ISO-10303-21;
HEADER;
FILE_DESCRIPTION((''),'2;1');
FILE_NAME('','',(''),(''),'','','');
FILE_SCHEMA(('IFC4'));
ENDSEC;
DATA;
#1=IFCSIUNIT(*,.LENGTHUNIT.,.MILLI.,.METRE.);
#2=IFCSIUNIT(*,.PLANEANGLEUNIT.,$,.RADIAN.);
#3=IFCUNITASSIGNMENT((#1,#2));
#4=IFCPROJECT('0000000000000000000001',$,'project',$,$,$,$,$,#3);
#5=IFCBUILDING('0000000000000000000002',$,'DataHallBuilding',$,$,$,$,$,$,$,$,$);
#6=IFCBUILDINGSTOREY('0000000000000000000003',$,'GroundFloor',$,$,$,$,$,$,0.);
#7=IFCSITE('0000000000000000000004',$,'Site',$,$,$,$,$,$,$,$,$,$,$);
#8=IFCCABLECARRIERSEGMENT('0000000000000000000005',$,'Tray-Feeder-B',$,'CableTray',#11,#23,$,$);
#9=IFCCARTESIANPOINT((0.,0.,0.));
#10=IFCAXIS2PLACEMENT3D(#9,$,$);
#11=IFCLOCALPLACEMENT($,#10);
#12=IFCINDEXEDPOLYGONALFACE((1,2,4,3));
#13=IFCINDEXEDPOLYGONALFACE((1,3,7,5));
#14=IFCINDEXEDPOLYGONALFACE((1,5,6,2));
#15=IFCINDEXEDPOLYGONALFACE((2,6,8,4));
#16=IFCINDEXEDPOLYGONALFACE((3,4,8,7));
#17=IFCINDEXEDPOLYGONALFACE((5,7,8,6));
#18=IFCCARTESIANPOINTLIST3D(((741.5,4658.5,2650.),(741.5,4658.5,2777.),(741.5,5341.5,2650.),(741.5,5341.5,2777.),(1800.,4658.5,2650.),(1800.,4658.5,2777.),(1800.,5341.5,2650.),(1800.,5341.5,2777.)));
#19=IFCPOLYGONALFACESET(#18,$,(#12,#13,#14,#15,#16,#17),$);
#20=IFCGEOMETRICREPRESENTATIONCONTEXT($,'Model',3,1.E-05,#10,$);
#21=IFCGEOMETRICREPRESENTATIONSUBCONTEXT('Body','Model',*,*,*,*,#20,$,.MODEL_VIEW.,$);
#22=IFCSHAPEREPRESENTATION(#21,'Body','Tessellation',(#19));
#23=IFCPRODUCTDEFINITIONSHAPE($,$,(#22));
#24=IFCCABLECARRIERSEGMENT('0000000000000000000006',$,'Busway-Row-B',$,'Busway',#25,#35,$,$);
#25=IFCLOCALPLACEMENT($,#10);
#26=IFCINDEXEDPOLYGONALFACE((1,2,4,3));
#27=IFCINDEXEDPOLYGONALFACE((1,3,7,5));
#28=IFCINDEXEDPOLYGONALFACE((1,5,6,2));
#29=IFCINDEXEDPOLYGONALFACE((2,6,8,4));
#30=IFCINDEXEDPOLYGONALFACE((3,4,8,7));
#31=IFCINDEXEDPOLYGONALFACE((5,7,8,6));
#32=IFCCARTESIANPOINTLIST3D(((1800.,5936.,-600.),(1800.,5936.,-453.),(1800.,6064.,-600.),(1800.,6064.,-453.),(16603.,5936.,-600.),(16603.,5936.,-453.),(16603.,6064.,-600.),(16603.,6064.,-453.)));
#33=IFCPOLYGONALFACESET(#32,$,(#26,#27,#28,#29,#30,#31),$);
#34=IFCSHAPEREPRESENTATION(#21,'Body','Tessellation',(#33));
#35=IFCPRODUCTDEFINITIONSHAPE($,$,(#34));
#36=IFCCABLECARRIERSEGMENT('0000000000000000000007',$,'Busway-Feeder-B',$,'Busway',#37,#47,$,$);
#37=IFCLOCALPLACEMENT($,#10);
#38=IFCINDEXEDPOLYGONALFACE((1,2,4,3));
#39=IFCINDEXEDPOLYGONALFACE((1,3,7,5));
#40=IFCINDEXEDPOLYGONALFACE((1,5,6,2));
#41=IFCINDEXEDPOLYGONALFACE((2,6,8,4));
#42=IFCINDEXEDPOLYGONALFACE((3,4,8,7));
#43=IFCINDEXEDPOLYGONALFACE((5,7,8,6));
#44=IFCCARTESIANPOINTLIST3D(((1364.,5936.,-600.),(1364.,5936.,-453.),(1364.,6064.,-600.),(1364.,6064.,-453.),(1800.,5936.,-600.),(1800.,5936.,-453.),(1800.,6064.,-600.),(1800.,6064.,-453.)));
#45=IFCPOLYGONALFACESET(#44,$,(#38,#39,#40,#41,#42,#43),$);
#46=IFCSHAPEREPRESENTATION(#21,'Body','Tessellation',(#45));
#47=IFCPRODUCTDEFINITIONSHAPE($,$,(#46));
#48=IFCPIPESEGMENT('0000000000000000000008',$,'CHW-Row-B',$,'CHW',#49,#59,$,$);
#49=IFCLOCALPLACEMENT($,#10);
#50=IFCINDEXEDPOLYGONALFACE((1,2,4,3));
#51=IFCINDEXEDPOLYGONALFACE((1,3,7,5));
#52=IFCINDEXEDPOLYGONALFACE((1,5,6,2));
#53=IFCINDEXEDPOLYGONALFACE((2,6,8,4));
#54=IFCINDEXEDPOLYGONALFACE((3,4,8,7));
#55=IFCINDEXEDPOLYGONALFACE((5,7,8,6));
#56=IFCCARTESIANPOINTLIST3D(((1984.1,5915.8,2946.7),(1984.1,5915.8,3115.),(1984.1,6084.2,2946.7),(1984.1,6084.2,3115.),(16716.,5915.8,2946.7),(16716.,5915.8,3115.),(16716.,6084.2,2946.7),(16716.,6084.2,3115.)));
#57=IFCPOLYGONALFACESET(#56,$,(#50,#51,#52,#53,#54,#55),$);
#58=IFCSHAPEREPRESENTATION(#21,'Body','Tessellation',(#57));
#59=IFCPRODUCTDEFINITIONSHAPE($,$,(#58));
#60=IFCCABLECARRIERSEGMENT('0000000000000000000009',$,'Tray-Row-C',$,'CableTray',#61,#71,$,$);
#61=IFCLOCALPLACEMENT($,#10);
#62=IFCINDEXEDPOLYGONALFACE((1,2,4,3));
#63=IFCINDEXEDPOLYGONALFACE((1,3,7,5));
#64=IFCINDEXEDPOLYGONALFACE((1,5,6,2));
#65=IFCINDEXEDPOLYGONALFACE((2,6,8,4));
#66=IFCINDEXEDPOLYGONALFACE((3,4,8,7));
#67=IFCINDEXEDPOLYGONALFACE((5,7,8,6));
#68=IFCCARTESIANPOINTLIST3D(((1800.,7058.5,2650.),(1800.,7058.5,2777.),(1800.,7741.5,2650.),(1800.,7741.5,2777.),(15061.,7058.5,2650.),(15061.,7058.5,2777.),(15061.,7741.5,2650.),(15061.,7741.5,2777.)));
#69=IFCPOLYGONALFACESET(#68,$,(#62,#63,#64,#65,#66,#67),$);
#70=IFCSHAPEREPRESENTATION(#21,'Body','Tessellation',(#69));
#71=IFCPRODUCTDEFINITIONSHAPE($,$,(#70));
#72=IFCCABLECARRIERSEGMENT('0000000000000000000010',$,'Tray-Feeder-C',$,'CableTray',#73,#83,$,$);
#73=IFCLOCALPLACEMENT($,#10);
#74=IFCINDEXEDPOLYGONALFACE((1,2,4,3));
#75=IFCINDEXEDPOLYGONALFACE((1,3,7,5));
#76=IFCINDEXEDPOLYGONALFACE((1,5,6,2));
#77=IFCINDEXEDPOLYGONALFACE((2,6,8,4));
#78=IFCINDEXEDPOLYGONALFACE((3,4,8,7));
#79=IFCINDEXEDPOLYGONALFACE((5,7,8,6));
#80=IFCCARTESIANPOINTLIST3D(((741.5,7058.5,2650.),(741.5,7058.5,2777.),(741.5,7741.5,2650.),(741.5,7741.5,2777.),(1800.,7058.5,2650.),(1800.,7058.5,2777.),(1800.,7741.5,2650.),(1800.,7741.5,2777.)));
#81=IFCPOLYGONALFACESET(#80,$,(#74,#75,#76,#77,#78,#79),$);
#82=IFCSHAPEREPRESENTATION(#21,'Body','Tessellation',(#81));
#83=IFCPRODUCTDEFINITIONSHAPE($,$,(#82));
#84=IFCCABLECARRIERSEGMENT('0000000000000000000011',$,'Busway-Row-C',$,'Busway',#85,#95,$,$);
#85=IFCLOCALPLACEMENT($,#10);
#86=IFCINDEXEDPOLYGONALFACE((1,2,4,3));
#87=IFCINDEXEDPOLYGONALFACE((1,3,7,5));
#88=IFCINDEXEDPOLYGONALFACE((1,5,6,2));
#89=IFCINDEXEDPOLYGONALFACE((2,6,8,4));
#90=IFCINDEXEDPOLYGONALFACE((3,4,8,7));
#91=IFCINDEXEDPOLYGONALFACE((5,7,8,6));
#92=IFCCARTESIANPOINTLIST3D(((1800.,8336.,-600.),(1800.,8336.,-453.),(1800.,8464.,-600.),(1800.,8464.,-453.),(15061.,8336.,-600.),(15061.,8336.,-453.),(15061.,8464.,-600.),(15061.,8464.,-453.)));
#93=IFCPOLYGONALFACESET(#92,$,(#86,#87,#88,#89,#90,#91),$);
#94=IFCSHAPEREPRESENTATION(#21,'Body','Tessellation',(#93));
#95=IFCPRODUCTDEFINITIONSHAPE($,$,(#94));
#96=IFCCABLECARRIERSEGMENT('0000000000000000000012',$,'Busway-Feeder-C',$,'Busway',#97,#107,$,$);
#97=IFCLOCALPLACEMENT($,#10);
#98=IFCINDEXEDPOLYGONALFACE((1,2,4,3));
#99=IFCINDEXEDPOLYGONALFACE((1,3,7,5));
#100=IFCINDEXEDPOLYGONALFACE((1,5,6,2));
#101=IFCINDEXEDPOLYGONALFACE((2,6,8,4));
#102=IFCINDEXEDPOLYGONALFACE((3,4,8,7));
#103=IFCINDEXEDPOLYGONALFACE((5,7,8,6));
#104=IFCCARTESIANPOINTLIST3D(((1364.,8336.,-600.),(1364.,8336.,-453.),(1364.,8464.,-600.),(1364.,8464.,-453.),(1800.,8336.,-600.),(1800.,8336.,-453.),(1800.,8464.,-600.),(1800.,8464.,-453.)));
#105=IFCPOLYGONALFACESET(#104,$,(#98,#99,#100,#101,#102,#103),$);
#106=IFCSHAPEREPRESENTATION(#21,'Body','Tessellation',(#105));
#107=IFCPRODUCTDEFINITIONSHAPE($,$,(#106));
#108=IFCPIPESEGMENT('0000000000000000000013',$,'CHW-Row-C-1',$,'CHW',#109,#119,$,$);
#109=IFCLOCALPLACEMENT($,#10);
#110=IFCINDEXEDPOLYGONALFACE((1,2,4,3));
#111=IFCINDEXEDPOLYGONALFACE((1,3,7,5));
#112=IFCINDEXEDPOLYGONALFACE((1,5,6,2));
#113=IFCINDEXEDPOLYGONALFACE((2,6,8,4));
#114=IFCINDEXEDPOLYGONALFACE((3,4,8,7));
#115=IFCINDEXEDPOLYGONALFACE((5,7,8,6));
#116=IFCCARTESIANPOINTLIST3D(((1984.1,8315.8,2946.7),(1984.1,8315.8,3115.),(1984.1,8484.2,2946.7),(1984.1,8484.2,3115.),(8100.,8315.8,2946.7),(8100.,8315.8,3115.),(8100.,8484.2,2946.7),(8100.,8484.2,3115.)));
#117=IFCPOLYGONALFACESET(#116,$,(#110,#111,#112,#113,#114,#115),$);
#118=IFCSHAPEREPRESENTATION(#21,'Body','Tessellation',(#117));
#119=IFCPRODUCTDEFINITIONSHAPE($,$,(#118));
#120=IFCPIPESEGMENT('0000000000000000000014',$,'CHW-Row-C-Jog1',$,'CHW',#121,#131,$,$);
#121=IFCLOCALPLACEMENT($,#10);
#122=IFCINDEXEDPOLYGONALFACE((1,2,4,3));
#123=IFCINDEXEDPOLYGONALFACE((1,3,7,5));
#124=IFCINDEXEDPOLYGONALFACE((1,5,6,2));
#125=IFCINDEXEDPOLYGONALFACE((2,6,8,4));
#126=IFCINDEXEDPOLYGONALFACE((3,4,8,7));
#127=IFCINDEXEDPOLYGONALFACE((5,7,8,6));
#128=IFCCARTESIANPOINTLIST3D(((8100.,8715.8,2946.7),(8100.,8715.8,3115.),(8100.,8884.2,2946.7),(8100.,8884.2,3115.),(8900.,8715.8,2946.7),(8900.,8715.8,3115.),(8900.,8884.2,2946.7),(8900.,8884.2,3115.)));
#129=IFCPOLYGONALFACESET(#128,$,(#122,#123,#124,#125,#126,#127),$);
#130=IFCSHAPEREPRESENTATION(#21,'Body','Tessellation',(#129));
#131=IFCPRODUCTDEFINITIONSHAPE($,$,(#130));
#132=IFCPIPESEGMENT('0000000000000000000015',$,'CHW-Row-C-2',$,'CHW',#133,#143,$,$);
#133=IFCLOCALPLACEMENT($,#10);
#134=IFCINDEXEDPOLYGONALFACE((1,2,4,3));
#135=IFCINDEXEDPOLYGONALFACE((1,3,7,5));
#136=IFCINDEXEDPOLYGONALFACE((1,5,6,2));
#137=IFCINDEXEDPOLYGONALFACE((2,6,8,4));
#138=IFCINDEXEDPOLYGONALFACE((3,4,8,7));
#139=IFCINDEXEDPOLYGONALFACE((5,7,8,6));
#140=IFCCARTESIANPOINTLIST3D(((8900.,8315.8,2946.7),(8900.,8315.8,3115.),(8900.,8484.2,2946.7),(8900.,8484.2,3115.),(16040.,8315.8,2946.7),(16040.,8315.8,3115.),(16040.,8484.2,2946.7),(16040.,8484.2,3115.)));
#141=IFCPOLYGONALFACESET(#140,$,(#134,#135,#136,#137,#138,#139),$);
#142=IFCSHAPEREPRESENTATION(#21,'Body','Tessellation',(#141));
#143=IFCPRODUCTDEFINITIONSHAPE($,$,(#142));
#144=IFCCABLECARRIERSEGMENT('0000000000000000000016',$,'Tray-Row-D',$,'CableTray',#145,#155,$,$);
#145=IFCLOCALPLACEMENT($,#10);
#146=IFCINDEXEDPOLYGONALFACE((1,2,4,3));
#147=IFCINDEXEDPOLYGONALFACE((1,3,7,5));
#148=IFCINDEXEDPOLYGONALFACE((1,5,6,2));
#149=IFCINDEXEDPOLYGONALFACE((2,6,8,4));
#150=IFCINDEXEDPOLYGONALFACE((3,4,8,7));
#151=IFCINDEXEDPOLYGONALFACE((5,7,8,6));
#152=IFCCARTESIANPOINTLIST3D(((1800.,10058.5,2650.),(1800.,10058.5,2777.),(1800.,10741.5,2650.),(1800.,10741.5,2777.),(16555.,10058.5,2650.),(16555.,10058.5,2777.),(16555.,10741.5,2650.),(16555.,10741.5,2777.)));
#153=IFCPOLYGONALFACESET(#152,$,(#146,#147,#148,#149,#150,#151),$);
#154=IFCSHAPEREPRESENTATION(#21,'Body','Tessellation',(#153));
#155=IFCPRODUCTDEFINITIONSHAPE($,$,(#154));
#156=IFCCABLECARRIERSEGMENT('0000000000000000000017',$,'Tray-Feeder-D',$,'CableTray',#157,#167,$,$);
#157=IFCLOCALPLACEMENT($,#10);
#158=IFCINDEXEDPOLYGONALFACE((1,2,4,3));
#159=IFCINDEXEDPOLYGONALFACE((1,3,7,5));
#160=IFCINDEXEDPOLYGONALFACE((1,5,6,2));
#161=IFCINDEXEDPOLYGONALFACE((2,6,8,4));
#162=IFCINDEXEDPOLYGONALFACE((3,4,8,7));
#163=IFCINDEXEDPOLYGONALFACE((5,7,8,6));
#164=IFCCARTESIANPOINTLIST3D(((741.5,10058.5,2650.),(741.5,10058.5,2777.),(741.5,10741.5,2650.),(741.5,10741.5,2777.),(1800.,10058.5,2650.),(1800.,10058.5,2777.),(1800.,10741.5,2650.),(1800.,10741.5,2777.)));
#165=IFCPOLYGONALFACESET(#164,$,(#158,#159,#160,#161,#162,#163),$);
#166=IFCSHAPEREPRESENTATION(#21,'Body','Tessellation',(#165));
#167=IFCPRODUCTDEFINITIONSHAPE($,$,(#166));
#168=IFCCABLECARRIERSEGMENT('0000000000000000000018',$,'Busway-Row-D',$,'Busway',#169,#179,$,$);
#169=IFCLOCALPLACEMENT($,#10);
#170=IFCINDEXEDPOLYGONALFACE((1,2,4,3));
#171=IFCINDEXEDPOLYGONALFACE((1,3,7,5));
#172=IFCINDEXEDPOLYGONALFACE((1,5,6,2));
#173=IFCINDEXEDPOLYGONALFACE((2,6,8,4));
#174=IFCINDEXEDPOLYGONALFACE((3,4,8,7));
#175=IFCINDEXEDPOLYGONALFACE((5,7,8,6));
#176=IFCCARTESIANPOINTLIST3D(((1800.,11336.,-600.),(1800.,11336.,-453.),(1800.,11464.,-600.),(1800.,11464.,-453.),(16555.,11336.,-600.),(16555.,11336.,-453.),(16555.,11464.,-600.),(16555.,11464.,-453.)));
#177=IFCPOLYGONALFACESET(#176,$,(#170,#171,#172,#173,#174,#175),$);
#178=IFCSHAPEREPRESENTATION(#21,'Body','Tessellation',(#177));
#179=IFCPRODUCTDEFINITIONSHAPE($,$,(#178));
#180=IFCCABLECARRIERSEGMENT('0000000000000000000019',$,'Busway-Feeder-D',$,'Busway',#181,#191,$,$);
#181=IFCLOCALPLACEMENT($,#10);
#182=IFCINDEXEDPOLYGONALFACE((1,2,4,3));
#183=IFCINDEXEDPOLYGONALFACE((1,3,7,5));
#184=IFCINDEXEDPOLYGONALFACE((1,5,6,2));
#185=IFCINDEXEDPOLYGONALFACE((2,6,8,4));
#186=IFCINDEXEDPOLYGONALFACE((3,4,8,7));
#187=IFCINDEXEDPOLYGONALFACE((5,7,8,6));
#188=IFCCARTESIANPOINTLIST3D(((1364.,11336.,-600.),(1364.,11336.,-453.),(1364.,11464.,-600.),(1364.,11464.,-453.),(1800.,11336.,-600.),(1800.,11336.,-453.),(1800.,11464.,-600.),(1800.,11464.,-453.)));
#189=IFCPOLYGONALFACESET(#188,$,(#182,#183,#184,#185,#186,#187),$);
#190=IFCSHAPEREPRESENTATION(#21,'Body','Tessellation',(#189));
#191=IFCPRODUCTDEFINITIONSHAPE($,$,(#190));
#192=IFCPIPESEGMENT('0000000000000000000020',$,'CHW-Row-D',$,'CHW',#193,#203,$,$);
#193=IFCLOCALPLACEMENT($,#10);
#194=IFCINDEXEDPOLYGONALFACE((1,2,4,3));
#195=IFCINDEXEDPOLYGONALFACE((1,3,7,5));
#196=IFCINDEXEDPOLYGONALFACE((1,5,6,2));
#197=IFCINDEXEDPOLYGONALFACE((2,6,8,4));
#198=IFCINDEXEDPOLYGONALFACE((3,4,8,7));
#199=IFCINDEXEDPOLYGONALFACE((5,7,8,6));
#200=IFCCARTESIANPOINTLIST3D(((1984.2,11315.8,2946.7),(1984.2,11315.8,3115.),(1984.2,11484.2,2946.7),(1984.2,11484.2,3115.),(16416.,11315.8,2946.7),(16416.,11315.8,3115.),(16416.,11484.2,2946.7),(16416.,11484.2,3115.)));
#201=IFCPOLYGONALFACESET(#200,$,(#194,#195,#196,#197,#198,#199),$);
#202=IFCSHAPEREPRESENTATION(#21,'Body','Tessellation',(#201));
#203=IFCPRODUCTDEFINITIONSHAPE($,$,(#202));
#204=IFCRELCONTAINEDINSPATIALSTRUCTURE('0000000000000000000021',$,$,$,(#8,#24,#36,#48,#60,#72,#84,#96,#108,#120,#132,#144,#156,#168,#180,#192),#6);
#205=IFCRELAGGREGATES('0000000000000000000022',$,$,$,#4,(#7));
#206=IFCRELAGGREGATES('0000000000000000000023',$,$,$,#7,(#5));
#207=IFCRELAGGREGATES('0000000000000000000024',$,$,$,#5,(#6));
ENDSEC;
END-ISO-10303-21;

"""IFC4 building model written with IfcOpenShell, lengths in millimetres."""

from ifc_helpers import new_model, si_unit, frame, origin, place, context, subcontext, project, spatial, rectangle, extrude, element, save


model = new_model("IFC4")

# Units and contexts
model_context = context("Model", 3, precision=1e-05, world=origin())
body_context = subcontext(model_context, "Body", "Model", "MODEL_VIEW")
ifc_project = project(units=[si_unit("LENGTHUNIT", "METRE", prefix="MILLI"), si_unit("PLANEANGLEUNIT", "RADIAN")])

# Site, building, storey
site = spatial("IfcSite", under=ifc_project, Name="Site")
building = spatial("IfcBuilding", under=site, Name="DataHallBuilding")
storey = spatial("IfcBuildingStorey", under=building, Name="GroundFloor", Elevation=0.0)

# Cable carrier segments
cable_carrier_segment_1_placement = place(None, origin())
element("IfcCableCarrierSegment", 1, at=cable_carrier_segment_1_placement, inside=storey, Name="Tray-Feeder-B", ObjectType="CableTray", context=body_context, shape_type="SweptSolid", body=[
    extrude(rectangle(XDim=1058.5, YDim=683.0), frame((1270.8, 5000.0, 2650.0), z_axis=(0.0, 0.0, 1.0), x_axis=(1.0, 0.0, 0.0)), (0.0, 0.0, 1.0), 127.0),
])
cable_carrier_segment_2_placement = place(None, origin())
element("IfcCableCarrierSegment", 2, at=cable_carrier_segment_2_placement, inside=storey, Name="Busway-Row-B", ObjectType="Busway", context=body_context, shape_type="SweptSolid", body=[
    extrude(rectangle(XDim=14803.0, YDim=128.0), frame((9201.5, 6000.0, -600.0), z_axis=(0.0, 0.0, 1.0), x_axis=(1.0, 0.0, 0.0)), (0.0, 0.0, 1.0), 147.0),
])
cable_carrier_segment_3_placement = place(None, origin())
element("IfcCableCarrierSegment", 3, at=cable_carrier_segment_3_placement, inside=storey, Name="Busway-Feeder-B", ObjectType="Busway", context=body_context, shape_type="SweptSolid", body=[
    extrude(rectangle(XDim=436.0, YDim=128.0), frame((1582.0, 6000.0, -600.0), z_axis=(0.0, 0.0, 1.0), x_axis=(1.0, 0.0, 0.0)), (0.0, 0.0, 1.0), 147.0),
])

# Pipe segment
pipe_segment_1_placement = place(None, origin())
element("IfcPipeSegment", 4, at=pipe_segment_1_placement, inside=storey, Name="CHW-Row-B", ObjectType="CHW", context=body_context, shape_type="SweptSolid", body=[
    extrude(rectangle(XDim=14731.9, YDim=168.3), frame((9350.1, 6000.0, 2946.7), z_axis=(0.0, 0.0, 1.0), x_axis=(1.0, 0.0, 0.0)), (0.0, 0.0, 1.0), 168.3),
])

# Cable carrier segments
cable_carrier_segment_4_placement = place(None, origin())
element("IfcCableCarrierSegment", 5, at=cable_carrier_segment_4_placement, inside=storey, Name="Tray-Row-C", ObjectType="CableTray", context=body_context, shape_type="SweptSolid", body=[
    extrude(rectangle(XDim=13261.0, YDim=683.0), frame((8430.5, 7400.0, 2650.0), z_axis=(0.0, 0.0, 1.0), x_axis=(1.0, 0.0, 0.0)), (0.0, 0.0, 1.0), 127.0),
])
cable_carrier_segment_5_placement = place(None, origin())
element("IfcCableCarrierSegment", 6, at=cable_carrier_segment_5_placement, inside=storey, Name="Tray-Feeder-C", ObjectType="CableTray", context=body_context, shape_type="SweptSolid", body=[
    extrude(rectangle(XDim=1058.5, YDim=683.0), frame((1270.8, 7400.0, 2650.0), z_axis=(0.0, 0.0, 1.0), x_axis=(1.0, 0.0, 0.0)), (0.0, 0.0, 1.0), 127.0),
])
cable_carrier_segment_6_placement = place(None, origin())
element("IfcCableCarrierSegment", 7, at=cable_carrier_segment_6_placement, inside=storey, Name="Busway-Row-C", ObjectType="Busway", context=body_context, shape_type="SweptSolid", body=[
    extrude(rectangle(XDim=13261.0, YDim=128.0), frame((8430.5, 8400.0, -600.0), z_axis=(0.0, 0.0, 1.0), x_axis=(1.0, 0.0, 0.0)), (0.0, 0.0, 1.0), 147.0),
])
cable_carrier_segment_7_placement = place(None, origin())
element("IfcCableCarrierSegment", 8, at=cable_carrier_segment_7_placement, inside=storey, Name="Busway-Feeder-C", ObjectType="Busway", context=body_context, shape_type="SweptSolid", body=[
    extrude(rectangle(XDim=436.0, YDim=128.0), frame((1582.0, 8400.0, -600.0), z_axis=(0.0, 0.0, 1.0), x_axis=(1.0, 0.0, 0.0)), (0.0, 0.0, 1.0), 147.0),
])

# Pipe segments
pipe_segment_2_placement = place(None, origin())
element("IfcPipeSegment", 9, at=pipe_segment_2_placement, inside=storey, Name="CHW-Row-C-1", ObjectType="CHW", context=body_context, shape_type="SweptSolid", body=[
    extrude(rectangle(XDim=6115.9, YDim=168.3), frame((5042.1, 8400.0, 2946.7), z_axis=(0.0, 0.0, 1.0), x_axis=(1.0, 0.0, 0.0)), (0.0, 0.0, 1.0), 168.3),
])
pipe_segment_3_placement = place(None, origin())
element("IfcPipeSegment", 10, at=pipe_segment_3_placement, inside=storey, Name="CHW-Row-C-Jog1", ObjectType="CHW", context=body_context, shape_type="SweptSolid", body=[
    extrude(rectangle(XDim=800.0, YDim=168.3), frame((8500.0, 8800.0, 2946.7), z_axis=(0.0, 0.0, 1.0), x_axis=(1.0, 0.0, 0.0)), (0.0, 0.0, 1.0), 168.3),
])
pipe_segment_4_placement = place(None, origin())
element("IfcPipeSegment", 11, at=pipe_segment_4_placement, inside=storey, Name="CHW-Row-C-2", ObjectType="CHW", context=body_context, shape_type="SweptSolid", body=[
    extrude(rectangle(XDim=7140.0, YDim=168.3), frame((12470.0, 8400.0, 2946.7), z_axis=(0.0, 0.0, 1.0), x_axis=(1.0, 0.0, 0.0)), (0.0, 0.0, 1.0), 168.3),
])

# Cable carrier segments
cable_carrier_segment_8_placement = place(None, origin())
element("IfcCableCarrierSegment", 12, at=cable_carrier_segment_8_placement, inside=storey, Name="Tray-Row-D", ObjectType="CableTray", context=body_context, shape_type="SweptSolid", body=[
    extrude(rectangle(XDim=14755.0, YDim=683.0), frame((9177.5, 10400.0, 2650.0), z_axis=(0.0, 0.0, 1.0), x_axis=(1.0, 0.0, 0.0)), (0.0, 0.0, 1.0), 127.0),
])
cable_carrier_segment_9_placement = place(None, origin())
element("IfcCableCarrierSegment", 13, at=cable_carrier_segment_9_placement, inside=storey, Name="Tray-Feeder-D", ObjectType="CableTray", context=body_context, shape_type="SweptSolid", body=[
    extrude(rectangle(XDim=1058.5, YDim=683.0), frame((1270.8, 10400.0, 2650.0), z_axis=(0.0, 0.0, 1.0), x_axis=(1.0, 0.0, 0.0)), (0.0, 0.0, 1.0), 127.0),
])
cable_carrier_segment_10_placement = place(None, origin())
element("IfcCableCarrierSegment", 14, at=cable_carrier_segment_10_placement, inside=storey, Name="Busway-Row-D", ObjectType="Busway", context=body_context, shape_type="SweptSolid", body=[
    extrude(rectangle(XDim=14755.0, YDim=128.0), frame((9177.5, 11400.0, -600.0), z_axis=(0.0, 0.0, 1.0), x_axis=(1.0, 0.0, 0.0)), (0.0, 0.0, 1.0), 147.0),
])
cable_carrier_segment_11_placement = place(None, origin())
element("IfcCableCarrierSegment", 15, at=cable_carrier_segment_11_placement, inside=storey, Name="Busway-Feeder-D", ObjectType="Busway", context=body_context, shape_type="SweptSolid", body=[
    extrude(rectangle(XDim=436.0, YDim=128.0), frame((1582.0, 11400.0, -600.0), z_axis=(0.0, 0.0, 1.0), x_axis=(1.0, 0.0, 0.0)), (0.0, 0.0, 1.0), 147.0),
])

# Pipe segment
pipe_segment_5_placement = place(None, origin())
element("IfcPipeSegment", 16, at=pipe_segment_5_placement, inside=storey, Name="CHW-Row-D", ObjectType="CHW", context=body_context, shape_type="SweptSolid", body=[
    extrude(rectangle(XDim=14431.9, YDim=168.3), frame((9200.1, 11400.0, 2946.7), z_axis=(0.0, 0.0, 1.0), x_axis=(1.0, 0.0, 0.0)), (0.0, 0.0, 1.0), 168.3),
])

save(model, "model.ifc")
